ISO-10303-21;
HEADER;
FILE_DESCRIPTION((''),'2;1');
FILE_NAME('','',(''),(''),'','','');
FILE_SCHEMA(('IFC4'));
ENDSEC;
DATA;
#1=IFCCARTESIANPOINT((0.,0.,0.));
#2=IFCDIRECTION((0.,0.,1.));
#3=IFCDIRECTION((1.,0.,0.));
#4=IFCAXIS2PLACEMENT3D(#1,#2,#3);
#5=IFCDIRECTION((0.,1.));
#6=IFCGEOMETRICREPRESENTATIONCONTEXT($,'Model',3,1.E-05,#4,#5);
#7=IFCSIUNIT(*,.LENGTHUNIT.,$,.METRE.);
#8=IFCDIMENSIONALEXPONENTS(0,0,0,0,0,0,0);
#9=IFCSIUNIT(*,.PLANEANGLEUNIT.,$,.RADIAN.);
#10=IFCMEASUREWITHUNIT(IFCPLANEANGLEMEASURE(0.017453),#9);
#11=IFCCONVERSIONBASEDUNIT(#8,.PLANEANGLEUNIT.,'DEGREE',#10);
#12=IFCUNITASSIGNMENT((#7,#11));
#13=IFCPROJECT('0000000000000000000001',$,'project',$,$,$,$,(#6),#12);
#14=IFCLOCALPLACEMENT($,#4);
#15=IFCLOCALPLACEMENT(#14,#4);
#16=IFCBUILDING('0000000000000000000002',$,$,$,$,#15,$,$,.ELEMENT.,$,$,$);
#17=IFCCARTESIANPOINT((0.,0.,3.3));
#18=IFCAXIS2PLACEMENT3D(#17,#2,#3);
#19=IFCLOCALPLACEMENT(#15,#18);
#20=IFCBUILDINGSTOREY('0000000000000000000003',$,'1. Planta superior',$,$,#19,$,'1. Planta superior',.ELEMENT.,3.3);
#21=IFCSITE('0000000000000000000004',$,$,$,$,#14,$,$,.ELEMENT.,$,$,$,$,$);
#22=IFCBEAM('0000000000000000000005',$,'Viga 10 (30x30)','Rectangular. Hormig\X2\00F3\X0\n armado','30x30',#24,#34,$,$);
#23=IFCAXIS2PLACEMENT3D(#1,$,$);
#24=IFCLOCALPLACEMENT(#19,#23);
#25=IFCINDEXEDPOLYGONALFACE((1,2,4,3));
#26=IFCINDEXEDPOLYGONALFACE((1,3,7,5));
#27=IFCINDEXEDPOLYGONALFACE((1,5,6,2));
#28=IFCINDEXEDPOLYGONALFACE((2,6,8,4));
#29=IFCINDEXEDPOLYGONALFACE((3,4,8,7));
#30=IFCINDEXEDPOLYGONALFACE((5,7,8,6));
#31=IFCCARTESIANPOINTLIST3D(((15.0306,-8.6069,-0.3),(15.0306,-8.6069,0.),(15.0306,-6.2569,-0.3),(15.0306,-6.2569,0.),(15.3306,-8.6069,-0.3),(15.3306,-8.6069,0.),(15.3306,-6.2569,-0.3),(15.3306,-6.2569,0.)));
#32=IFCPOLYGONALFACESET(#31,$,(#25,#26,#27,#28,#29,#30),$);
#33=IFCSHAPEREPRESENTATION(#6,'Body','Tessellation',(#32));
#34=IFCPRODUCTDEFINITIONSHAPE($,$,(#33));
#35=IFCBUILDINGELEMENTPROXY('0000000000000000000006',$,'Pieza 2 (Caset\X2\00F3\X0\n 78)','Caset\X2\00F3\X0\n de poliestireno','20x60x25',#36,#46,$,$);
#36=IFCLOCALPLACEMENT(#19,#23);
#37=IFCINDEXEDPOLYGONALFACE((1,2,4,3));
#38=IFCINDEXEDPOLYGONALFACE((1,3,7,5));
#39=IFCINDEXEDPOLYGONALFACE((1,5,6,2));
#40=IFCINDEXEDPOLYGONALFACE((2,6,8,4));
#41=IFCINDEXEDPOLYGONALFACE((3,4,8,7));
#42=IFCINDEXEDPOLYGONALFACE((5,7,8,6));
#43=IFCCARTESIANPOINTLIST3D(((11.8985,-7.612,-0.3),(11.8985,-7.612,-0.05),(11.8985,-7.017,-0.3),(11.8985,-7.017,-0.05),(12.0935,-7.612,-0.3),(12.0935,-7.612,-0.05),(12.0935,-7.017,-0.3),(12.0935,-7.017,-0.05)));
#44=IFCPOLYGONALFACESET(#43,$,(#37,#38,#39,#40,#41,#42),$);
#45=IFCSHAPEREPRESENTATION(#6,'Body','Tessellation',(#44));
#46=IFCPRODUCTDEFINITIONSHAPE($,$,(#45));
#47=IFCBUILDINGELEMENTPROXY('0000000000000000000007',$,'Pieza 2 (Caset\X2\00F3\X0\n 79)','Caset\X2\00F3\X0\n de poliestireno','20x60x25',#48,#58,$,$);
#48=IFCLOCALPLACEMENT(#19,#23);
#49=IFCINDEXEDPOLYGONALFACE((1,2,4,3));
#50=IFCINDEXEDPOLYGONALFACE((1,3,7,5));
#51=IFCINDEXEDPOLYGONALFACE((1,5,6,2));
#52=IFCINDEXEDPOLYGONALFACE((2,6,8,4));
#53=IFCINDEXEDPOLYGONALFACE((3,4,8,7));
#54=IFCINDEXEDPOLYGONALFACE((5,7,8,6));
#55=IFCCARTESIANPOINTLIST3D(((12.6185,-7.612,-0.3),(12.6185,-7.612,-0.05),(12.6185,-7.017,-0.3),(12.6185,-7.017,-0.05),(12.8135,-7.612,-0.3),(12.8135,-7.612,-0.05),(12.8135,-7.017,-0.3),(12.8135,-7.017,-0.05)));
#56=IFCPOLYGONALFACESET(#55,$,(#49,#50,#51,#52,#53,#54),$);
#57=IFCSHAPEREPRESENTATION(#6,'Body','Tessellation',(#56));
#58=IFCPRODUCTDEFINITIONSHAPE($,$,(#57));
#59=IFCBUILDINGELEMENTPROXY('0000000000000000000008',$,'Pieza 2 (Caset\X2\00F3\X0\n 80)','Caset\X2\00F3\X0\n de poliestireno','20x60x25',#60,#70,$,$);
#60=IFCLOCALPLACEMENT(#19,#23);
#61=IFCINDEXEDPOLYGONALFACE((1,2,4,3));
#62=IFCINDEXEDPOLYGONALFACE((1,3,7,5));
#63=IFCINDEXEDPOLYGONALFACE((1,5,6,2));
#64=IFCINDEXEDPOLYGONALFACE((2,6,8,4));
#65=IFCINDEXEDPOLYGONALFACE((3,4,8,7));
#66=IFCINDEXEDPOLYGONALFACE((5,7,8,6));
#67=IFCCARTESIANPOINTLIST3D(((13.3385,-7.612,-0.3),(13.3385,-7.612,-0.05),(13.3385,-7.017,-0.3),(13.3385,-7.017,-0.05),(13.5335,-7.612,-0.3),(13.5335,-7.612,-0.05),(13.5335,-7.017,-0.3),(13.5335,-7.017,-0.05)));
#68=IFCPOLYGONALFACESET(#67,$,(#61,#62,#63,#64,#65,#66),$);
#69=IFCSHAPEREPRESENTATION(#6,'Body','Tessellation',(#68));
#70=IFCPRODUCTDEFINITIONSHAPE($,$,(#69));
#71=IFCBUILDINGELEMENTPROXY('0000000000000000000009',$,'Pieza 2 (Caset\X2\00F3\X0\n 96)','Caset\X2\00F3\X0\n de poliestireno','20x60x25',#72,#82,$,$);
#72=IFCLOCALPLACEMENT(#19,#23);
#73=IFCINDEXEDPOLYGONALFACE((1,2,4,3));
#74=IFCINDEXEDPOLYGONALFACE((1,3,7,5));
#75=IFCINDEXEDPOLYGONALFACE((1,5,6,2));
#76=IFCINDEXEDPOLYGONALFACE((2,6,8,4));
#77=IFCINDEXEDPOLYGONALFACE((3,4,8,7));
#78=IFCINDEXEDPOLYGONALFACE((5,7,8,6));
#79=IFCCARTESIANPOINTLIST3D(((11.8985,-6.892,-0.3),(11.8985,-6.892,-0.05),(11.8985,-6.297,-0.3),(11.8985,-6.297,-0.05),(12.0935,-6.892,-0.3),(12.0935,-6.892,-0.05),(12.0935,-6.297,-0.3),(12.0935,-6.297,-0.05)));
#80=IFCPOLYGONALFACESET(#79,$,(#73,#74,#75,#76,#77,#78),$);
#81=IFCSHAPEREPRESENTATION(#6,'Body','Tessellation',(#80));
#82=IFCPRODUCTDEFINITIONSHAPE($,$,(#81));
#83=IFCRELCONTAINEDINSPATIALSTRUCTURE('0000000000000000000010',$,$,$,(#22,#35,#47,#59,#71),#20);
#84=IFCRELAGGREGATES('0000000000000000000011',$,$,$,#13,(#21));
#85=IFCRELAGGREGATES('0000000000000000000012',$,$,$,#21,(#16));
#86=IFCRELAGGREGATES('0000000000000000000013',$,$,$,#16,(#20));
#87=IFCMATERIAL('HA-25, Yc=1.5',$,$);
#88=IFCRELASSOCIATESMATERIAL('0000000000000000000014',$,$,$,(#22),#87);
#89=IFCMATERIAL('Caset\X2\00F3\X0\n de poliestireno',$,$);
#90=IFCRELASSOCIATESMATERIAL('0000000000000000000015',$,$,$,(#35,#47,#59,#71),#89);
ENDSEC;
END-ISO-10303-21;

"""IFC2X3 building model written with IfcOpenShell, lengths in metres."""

from ifc_helpers import new_model, entity, si_unit, converted_unit, direction, frame, frame_2d, origin_with_axes, origin_2d_with_axis, place, context, project, spatial, rectangle, extrude, source, transform, mapped, material, element, save


model = new_model("IFC2X3")

# Units and contexts
model_context = context("Model", 3, precision=1e-05, world=origin_with_axes(), true_north=direction((0.0, 1.0)))
ifc_project = project(units=[si_unit("LENGTHUNIT", "METRE"), converted_unit("PLANEANGLEUNIT", "DEGREE", entity("IfcPlaneAngleMeasure", 0.017453), si_unit("PLANEANGLEUNIT", "RADIAN"), dimensions=[0, 0, 0, 0, 0, 0, 0])], contexts=[model_context])

# Site, building, storey
site_placement = place(None, origin_with_axes())
site = spatial("IfcSite", under=ifc_project, at=site_placement, CompositionType="ELEMENT")
building_placement = place(site_placement, origin_with_axes())
building = spatial("IfcBuilding", under=site, at=building_placement, CompositionType="ELEMENT")
storey_placement = place(building_placement, frame((0.0, 0.0, 3.3), z_axis=(0.0, 0.0, 1.0), x_axis=(1.0, 0.0, 0.0)))
storey = spatial("IfcBuildingStorey", under=building, at=storey_placement, Name="1. Planta superior", LongName="1. Planta superior", CompositionType="ELEMENT", Elevation=3.3)

# Beam
ifc_material_1 = material(Name="HA-25, Yc=1.5")
beam_placement = place(storey_placement, frame((15.1806, -8.6069, 0.0), z_axis=(0.0, 1.0, 0.0), x_axis=(-1.0, 0.0, 0.0)))
element("IfcBeam", 1, at=beam_placement, inside=storey, material=ifc_material_1, Name="Viga 10 (30x30)", Description="Rectangular. Hormigón armado", ObjectType="30x30", context=model_context, shape_type="SweptSolid", body=[
    extrude(rectangle(XDim=0.3, YDim=0.3, at=frame_2d((0.0, -0.15), x_axis=(1.0, 0.0))), origin_with_axes(), (0.0, 0.0, 1.0), 2.35),
])

# Building element proxies
ifc_material_2 = material(Name="Casetón de poliestireno")
shared_shape = source(origin_with_axes(), model_context, "Body", "SweptSolid", [
    extrude(rectangle(XDim=0.195, YDim=0.25, at=origin_2d_with_axis()), origin_with_axes(), (0.0, 0.0, 1.0), 0.595),
])
placement_1 = place(storey_placement, frame((11.996, -7.612, -0.175), z_axis=(0.0, 1.0, 0.0), x_axis=(-1.0, 0.0, 0.0)))
for number, where, z_axis, x_axis, name in (
    (2, (0.0, 0.0, 0.0), (0.0, 0.0, 1.0), (1.0, 0.0, 0.0), "Pieza 2 (Casetón 78)"),
):
    element("IfcBuildingElementProxy", number, at=place(placement_1, frame(where, z_axis=z_axis, x_axis=x_axis)), inside=storey, material=ifc_material_2, Name=name, Description="Casetón de poliestireno", ObjectType="20x60x25", context=model_context, shape_type="MappedRepresentation", body=[
        mapped(shared_shape, transform((0.0, 0.0, 0.0), x_axis=(1.0, 0.0, 0.0), y_axis=(0.0, 1.0, 0.0), z_axis=(0.0, 0.0, 1.0))),
    ])
placement_2 = place(storey_placement, frame((12.716, -7.612, -0.175), z_axis=(0.0, 1.0, 0.0), x_axis=(-1.0, 0.0, 0.0)))
for number, where, z_axis, x_axis, name in (
    (3, (0.0, 0.0, 0.0), (0.0, 0.0, 1.0), (1.0, 0.0, 0.0), "Pieza 2 (Casetón 79)"),
):
    element("IfcBuildingElementProxy", number, at=place(placement_2, frame(where, z_axis=z_axis, x_axis=x_axis)), inside=storey, material=ifc_material_2, Name=name, Description="Casetón de poliestireno", ObjectType="20x60x25", context=model_context, shape_type="MappedRepresentation", body=[
        mapped(shared_shape, transform((0.0, 0.0, 0.0), x_axis=(1.0, 0.0, 0.0), y_axis=(0.0, 1.0, 0.0), z_axis=(0.0, 0.0, 1.0))),
    ])
placement_3 = place(storey_placement, frame((13.436, -7.612, -0.175), z_axis=(0.0, 1.0, 0.0), x_axis=(-1.0, 0.0, 0.0)))
for number, where, z_axis, x_axis, name in (
    (4, (0.0, 0.0, 0.0), (0.0, 0.0, 1.0), (1.0, 0.0, 0.0), "Pieza 2 (Casetón 80)"),
):
    element("IfcBuildingElementProxy", number, at=place(placement_3, frame(where, z_axis=z_axis, x_axis=x_axis)), inside=storey, material=ifc_material_2, Name=name, Description="Casetón de poliestireno", ObjectType="20x60x25", context=model_context, shape_type="MappedRepresentation", body=[
        mapped(shared_shape, transform((0.0, 0.0, 0.0), x_axis=(1.0, 0.0, 0.0), y_axis=(0.0, 1.0, 0.0), z_axis=(0.0, 0.0, 1.0))),
    ])
placement_4 = place(storey_placement, frame((11.996, -6.892, -0.175), z_axis=(0.0, 1.0, 0.0), x_axis=(-1.0, 0.0, 0.0)))
for number, where, z_axis, x_axis, name in (
    (5, (0.0, 0.0, 0.0), (0.0, 0.0, 1.0), (1.0, 0.0, 0.0), "Pieza 2 (Casetón 96)"),
):
    element("IfcBuildingElementProxy", number, at=place(placement_4, frame(where, z_axis=z_axis, x_axis=x_axis)), inside=storey, material=ifc_material_2, Name=name, Description="Casetón de poliestireno", ObjectType="20x60x25", context=model_context, shape_type="MappedRepresentation", body=[
        mapped(shared_shape, transform((0.0, 0.0, 0.0), x_axis=(1.0, 0.0, 0.0), y_axis=(0.0, 1.0, 0.0), z_axis=(0.0, 0.0, 1.0))),
    ])

save(model, "model.ifc")
